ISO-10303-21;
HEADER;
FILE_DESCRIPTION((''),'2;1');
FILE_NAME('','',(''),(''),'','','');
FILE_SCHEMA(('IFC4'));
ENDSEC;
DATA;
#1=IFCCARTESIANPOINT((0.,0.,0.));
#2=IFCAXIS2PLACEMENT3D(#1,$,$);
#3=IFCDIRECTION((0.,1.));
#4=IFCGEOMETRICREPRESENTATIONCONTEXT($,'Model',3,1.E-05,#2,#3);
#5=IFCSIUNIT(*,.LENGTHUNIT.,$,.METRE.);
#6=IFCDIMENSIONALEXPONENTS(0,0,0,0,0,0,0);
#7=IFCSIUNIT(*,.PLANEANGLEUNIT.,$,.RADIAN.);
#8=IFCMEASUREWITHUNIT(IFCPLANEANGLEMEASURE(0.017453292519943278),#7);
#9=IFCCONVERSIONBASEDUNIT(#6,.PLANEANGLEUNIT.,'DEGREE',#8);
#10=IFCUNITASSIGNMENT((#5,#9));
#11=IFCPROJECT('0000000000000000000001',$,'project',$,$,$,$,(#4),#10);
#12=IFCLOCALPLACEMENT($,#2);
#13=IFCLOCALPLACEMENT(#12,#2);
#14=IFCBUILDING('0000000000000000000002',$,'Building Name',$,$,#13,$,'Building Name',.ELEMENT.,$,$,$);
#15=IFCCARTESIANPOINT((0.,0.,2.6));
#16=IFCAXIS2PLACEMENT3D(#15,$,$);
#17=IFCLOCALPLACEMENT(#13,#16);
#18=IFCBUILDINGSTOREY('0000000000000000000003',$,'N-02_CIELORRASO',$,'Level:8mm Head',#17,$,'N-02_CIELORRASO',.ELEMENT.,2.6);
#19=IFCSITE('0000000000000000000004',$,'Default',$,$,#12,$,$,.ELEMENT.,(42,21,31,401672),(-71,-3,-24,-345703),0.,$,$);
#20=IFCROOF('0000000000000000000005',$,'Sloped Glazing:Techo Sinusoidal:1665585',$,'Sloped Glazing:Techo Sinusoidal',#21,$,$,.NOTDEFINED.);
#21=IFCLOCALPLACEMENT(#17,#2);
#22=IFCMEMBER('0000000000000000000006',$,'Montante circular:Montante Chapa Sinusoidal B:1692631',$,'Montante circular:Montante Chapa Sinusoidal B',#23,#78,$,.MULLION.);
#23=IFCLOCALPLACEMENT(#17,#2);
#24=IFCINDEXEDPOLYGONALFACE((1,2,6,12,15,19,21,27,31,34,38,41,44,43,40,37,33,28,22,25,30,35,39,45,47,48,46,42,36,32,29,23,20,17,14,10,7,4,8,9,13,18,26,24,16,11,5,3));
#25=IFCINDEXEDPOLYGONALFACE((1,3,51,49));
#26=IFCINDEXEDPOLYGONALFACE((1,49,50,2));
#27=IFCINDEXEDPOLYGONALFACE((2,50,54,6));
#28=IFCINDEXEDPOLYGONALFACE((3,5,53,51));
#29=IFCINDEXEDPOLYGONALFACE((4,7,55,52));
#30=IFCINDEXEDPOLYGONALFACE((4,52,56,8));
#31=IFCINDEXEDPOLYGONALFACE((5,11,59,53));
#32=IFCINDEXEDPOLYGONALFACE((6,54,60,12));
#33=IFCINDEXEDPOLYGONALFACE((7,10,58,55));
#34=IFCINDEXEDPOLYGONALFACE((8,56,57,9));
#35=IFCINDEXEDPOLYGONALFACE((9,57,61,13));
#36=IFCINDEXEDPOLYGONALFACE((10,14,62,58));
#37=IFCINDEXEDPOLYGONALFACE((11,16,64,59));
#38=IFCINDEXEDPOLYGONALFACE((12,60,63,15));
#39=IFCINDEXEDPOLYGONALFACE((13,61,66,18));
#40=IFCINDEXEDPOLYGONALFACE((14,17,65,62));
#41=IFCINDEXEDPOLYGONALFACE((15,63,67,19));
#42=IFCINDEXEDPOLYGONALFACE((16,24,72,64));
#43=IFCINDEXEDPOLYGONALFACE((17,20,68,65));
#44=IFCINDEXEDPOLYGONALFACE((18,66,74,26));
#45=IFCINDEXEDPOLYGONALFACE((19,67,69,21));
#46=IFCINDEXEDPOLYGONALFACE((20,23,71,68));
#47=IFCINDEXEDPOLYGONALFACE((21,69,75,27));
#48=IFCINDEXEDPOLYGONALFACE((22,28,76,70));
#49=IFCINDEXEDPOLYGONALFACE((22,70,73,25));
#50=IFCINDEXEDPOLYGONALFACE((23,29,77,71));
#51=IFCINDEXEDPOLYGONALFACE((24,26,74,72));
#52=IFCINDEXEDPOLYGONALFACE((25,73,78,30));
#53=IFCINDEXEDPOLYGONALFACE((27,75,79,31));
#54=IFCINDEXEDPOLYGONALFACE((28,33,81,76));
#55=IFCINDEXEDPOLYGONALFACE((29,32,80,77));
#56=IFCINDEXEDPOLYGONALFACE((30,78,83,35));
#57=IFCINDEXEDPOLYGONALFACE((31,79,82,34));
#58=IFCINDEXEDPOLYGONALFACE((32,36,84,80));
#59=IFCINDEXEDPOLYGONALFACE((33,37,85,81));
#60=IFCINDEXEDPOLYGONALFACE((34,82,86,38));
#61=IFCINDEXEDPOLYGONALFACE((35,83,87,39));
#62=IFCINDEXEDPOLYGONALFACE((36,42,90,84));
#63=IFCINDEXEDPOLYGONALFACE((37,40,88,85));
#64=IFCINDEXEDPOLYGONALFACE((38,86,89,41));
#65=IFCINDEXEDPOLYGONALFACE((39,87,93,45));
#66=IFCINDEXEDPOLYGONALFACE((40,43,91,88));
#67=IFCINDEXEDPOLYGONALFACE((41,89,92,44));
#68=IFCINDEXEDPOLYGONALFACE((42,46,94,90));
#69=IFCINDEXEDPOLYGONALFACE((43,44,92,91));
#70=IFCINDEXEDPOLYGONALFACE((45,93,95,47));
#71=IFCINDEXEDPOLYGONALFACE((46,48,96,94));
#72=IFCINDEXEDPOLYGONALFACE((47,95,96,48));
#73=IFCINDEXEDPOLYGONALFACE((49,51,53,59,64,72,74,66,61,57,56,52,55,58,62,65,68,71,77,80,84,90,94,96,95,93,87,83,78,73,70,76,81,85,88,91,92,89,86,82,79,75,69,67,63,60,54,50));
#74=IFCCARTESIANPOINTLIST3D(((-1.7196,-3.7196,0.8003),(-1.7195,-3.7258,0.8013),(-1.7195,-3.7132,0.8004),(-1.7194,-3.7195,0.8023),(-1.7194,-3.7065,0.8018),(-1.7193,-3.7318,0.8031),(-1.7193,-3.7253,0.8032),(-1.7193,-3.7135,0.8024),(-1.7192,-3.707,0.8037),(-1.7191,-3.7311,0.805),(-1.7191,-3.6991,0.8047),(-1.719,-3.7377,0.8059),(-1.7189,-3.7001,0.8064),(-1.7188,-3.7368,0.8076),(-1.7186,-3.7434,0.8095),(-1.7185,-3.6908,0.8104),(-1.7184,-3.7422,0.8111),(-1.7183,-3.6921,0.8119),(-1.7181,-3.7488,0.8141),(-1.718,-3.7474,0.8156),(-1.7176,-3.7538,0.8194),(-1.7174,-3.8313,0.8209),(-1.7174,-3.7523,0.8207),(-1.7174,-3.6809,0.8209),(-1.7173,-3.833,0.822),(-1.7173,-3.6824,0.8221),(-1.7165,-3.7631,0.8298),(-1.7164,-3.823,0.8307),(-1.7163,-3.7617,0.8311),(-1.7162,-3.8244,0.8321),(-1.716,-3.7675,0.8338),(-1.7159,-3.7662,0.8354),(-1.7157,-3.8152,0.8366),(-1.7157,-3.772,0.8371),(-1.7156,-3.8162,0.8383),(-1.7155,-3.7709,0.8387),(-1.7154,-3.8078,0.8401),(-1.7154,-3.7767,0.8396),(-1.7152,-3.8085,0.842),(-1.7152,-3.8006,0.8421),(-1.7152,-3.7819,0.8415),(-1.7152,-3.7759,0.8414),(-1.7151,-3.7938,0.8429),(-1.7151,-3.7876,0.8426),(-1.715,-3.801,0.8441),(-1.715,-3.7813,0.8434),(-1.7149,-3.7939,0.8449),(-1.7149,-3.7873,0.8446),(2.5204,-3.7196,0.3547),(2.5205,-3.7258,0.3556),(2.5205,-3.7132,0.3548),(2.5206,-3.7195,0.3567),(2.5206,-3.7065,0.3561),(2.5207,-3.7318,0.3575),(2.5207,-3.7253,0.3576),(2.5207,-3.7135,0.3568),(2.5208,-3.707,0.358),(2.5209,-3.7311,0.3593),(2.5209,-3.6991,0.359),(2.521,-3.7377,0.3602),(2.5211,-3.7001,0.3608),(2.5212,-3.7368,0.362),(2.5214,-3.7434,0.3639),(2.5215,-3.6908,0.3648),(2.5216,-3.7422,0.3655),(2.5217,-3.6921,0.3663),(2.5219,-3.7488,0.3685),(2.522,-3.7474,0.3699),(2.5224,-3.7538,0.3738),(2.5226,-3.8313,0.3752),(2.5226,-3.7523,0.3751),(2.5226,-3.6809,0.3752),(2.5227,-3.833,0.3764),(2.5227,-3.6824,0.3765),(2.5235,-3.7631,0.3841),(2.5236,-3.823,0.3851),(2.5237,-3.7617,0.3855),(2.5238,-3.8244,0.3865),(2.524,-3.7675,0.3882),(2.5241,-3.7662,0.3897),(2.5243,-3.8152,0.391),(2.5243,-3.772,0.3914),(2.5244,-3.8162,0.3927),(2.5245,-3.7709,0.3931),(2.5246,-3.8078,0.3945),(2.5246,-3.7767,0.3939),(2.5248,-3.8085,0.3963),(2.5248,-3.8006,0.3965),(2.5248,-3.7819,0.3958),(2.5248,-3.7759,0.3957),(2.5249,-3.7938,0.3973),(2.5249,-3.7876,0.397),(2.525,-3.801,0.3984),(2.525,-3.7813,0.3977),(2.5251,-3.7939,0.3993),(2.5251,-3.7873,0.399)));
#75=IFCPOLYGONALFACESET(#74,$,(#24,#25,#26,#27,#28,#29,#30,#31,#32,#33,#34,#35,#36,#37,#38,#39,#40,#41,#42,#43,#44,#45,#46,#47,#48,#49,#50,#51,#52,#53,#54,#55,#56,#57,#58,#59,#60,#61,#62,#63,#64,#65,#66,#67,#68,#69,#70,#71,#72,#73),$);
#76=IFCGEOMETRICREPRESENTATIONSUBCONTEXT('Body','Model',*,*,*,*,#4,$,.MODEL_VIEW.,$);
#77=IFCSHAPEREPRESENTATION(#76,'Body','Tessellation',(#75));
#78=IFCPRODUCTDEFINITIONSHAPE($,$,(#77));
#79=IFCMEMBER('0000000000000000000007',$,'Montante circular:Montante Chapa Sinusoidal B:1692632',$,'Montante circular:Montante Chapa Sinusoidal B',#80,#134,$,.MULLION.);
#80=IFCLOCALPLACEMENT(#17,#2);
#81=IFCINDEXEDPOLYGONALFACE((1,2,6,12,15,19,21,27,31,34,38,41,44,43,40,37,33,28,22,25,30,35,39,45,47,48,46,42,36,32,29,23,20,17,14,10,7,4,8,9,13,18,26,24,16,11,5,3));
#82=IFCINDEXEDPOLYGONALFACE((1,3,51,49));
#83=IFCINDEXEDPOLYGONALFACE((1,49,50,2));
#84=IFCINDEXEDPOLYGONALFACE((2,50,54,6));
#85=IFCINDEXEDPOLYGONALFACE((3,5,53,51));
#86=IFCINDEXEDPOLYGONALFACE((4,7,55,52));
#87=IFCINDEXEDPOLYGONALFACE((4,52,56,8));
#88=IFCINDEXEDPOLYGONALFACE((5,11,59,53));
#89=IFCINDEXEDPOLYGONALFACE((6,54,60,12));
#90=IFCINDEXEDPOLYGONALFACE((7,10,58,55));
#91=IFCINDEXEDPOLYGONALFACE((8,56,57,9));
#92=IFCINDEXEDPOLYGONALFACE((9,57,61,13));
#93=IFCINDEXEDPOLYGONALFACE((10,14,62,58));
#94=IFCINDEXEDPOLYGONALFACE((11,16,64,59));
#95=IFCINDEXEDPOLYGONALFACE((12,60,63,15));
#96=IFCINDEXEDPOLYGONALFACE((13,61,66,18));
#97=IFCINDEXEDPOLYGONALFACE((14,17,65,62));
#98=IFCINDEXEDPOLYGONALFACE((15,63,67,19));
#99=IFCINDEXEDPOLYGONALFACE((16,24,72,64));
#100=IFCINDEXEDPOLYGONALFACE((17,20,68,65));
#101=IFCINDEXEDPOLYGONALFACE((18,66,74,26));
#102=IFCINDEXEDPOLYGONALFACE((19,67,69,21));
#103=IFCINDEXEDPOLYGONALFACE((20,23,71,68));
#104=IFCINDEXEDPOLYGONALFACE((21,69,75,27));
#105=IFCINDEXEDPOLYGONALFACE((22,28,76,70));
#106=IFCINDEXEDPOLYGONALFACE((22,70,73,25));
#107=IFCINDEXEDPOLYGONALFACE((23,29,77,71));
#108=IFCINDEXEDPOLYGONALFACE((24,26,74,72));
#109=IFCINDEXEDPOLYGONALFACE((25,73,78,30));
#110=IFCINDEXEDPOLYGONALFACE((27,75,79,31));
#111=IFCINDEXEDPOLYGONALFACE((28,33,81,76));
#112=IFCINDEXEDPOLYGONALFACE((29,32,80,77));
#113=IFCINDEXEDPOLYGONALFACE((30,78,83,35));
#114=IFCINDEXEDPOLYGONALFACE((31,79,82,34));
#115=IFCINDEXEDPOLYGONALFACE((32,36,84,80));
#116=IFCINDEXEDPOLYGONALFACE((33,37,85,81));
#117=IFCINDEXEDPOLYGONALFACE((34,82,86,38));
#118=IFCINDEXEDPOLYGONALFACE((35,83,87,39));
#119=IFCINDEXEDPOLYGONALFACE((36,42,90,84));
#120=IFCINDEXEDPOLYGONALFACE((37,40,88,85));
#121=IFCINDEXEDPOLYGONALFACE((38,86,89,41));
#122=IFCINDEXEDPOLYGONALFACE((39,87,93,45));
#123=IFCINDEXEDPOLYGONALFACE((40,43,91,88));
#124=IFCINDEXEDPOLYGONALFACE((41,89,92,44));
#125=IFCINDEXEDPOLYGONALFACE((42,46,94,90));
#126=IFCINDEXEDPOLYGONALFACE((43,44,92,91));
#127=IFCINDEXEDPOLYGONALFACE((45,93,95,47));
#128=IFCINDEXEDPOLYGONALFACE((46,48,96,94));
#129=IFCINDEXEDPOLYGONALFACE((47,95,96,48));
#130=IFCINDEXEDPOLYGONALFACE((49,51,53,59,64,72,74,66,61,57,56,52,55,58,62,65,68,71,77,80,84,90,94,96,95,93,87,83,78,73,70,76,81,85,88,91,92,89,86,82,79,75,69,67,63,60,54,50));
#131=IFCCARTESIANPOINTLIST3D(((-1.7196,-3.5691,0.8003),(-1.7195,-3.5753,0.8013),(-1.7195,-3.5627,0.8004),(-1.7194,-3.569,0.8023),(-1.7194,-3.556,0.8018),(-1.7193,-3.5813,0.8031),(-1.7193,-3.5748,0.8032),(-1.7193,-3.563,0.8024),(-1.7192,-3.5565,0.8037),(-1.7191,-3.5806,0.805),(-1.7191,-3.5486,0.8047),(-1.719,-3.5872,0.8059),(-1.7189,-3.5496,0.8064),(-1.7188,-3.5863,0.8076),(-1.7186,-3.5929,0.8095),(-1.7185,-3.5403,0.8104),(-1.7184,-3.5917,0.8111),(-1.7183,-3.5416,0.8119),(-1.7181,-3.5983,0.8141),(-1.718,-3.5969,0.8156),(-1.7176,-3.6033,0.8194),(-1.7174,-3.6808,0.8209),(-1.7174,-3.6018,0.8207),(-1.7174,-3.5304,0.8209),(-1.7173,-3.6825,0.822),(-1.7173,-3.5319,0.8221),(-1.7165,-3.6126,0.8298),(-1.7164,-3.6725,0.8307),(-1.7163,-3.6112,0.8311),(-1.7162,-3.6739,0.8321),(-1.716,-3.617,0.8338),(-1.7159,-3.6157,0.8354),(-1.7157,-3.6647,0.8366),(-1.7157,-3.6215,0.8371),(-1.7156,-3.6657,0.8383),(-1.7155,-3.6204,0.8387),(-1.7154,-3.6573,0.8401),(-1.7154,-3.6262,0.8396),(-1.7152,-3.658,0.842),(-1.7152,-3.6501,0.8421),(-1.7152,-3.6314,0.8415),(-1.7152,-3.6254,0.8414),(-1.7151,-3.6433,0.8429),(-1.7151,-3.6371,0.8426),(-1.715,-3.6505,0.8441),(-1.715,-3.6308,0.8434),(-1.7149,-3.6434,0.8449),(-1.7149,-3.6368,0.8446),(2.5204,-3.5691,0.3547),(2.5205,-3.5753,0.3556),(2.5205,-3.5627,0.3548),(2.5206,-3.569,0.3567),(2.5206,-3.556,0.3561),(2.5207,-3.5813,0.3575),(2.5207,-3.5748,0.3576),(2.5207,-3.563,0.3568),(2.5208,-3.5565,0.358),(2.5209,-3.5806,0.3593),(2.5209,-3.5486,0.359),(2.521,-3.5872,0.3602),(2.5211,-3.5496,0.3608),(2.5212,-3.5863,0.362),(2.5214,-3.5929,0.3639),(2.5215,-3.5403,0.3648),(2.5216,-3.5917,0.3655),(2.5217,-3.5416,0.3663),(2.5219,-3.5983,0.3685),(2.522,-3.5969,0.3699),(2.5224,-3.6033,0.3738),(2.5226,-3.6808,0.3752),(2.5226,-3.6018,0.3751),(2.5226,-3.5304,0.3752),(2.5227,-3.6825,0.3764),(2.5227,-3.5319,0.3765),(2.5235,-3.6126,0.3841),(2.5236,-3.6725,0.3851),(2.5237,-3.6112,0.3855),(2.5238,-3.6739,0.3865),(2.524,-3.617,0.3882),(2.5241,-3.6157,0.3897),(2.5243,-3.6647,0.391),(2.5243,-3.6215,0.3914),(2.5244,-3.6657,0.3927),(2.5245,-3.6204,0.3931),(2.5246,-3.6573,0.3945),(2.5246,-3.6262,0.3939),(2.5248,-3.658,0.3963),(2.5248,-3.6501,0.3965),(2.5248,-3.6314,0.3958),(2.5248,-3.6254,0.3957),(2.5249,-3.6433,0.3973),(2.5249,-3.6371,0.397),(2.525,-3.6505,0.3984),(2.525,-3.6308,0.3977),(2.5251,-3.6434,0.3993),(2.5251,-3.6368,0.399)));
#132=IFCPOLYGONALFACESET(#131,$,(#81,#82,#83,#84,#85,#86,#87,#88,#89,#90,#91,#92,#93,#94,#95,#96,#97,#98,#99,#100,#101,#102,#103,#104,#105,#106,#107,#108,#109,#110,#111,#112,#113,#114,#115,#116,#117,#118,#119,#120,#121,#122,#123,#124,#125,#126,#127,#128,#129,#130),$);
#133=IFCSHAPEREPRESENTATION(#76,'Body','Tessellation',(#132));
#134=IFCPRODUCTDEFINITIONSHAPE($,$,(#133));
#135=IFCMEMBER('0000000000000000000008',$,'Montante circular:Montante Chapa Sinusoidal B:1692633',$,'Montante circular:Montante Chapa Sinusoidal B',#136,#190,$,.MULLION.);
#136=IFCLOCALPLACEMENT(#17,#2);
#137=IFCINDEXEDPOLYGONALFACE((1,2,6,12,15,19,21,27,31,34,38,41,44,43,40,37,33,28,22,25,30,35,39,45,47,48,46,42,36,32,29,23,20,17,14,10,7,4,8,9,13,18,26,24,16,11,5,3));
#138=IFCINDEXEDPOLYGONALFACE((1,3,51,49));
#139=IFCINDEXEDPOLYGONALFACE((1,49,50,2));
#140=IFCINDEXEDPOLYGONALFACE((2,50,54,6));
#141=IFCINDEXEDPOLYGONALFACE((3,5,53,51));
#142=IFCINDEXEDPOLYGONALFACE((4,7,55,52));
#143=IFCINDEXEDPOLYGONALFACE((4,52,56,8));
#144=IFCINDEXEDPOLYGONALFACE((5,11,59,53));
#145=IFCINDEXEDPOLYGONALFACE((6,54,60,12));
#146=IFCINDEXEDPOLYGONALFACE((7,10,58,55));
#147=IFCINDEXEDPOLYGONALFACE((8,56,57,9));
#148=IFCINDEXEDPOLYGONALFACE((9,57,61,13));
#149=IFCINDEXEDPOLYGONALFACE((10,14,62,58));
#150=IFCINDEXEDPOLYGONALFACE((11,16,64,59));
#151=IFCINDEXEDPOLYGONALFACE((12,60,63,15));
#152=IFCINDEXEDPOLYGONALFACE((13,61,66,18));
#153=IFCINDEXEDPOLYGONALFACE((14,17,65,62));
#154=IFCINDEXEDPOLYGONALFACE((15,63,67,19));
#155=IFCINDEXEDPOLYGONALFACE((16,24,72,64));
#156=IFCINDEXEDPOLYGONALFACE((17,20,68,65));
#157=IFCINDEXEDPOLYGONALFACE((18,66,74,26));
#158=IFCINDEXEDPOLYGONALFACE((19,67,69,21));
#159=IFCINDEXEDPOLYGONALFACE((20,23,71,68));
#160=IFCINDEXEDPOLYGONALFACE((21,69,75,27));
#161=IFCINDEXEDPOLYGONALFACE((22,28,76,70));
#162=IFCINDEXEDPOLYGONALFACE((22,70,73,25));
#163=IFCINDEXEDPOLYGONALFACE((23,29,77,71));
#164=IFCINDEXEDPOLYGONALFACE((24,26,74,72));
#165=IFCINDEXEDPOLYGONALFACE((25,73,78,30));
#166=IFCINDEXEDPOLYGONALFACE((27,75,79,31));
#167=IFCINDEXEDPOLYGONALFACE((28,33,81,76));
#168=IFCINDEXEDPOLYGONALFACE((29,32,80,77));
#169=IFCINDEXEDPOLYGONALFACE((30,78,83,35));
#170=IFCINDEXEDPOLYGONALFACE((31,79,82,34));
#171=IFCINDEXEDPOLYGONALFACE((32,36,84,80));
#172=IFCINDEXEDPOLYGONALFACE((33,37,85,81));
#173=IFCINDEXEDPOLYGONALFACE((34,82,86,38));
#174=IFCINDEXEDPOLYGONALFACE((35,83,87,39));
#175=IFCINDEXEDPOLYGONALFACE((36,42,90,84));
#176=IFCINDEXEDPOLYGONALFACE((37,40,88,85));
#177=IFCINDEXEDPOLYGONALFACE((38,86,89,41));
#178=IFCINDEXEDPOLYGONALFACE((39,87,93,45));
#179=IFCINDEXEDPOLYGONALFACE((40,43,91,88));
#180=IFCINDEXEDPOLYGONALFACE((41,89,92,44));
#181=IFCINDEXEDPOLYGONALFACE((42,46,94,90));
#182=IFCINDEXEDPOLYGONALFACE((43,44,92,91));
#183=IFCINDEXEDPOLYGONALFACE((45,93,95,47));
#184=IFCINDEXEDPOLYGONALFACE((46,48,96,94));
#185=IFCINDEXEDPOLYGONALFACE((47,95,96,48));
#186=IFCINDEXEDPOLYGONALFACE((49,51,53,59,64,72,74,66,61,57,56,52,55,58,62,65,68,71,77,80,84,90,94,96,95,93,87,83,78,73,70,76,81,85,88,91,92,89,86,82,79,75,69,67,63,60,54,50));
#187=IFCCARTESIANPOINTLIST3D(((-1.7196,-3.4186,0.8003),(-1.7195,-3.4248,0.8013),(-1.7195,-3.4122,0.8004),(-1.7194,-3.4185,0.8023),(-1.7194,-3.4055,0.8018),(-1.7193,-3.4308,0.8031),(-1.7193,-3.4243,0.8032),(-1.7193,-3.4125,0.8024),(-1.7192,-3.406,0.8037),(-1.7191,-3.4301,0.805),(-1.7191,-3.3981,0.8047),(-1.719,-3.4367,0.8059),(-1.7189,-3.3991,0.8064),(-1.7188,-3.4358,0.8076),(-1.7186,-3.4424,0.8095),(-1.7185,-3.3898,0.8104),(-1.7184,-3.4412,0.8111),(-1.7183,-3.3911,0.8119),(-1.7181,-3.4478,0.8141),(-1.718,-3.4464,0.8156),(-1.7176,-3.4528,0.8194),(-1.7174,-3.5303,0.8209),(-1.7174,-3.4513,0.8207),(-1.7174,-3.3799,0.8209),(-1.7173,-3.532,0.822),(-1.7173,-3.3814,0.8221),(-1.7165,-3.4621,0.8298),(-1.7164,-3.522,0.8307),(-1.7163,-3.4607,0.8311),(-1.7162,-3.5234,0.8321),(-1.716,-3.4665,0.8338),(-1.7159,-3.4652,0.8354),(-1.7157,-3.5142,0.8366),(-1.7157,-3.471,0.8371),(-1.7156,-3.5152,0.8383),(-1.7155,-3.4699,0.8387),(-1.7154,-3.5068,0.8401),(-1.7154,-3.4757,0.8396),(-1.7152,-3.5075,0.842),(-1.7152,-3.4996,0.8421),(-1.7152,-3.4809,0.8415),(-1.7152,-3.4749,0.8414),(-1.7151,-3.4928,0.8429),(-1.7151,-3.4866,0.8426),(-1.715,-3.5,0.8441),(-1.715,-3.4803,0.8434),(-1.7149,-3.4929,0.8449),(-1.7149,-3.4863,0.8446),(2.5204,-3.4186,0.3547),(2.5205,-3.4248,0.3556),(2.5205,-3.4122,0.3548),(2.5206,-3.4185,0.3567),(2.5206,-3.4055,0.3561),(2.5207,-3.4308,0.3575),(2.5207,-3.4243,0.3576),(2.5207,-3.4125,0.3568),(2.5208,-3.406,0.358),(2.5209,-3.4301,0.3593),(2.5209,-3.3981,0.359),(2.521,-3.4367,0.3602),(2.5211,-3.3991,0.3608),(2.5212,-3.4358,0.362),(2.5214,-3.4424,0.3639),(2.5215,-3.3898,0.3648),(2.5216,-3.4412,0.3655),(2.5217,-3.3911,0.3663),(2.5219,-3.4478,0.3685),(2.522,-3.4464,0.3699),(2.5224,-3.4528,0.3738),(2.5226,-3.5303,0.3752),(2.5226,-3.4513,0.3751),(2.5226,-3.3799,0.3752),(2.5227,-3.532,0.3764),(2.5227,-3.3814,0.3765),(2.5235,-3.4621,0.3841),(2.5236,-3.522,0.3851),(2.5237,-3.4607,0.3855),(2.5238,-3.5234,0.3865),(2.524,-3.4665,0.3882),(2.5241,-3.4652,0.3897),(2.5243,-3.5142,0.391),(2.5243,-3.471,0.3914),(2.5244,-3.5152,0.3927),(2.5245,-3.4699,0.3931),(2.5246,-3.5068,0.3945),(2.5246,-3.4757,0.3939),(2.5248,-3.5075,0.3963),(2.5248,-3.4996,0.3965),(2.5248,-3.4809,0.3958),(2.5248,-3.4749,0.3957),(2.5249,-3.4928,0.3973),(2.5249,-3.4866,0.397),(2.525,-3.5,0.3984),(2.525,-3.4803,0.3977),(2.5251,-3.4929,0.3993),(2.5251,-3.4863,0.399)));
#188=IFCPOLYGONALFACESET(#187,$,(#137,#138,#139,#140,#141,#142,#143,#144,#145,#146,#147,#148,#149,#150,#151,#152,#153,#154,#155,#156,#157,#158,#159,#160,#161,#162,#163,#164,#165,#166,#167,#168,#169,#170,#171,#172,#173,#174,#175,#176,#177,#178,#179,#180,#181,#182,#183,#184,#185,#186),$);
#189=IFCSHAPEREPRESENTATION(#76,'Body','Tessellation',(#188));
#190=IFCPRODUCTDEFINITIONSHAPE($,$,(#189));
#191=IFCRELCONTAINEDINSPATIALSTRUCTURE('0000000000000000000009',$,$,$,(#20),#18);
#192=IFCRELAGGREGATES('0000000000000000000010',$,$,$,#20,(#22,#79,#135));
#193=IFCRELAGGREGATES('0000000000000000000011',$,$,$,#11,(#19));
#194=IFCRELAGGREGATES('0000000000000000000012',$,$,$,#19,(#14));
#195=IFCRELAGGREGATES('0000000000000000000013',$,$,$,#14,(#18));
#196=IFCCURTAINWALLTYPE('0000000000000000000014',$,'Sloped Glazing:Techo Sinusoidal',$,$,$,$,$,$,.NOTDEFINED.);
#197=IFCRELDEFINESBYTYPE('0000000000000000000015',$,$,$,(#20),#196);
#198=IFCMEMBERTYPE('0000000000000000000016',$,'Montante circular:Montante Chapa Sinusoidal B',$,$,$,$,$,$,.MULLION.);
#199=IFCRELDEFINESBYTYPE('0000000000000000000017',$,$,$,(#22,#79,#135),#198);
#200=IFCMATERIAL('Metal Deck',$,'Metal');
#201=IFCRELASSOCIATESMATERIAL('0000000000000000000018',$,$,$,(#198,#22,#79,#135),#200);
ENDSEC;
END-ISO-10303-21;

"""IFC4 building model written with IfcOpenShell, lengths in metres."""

from ifc_helpers import new_model, entity, si_unit, converted_unit, direction, frame, origin, place, context, subcontext, project, spatial, indexed_curve, outline, extrude, source, transform, mapped, material, type_object, type_shapes, element, aggregate, save


model = new_model("IFC4")

# Units and contexts
model_context = context("Model", 3, precision=1e-05, world=origin(), true_north=direction((0.0, 1.0)))
body_context = subcontext(model_context, "Body", "Model", "MODEL_VIEW")
ifc_project = project(units=[si_unit("LENGTHUNIT", "METRE"), converted_unit("PLANEANGLEUNIT", "DEGREE", entity("IfcPlaneAngleMeasure", 0.017453292519943278), si_unit("PLANEANGLEUNIT", "RADIAN"), dimensions=[0, 0, 0, 0, 0, 0, 0])], contexts=[model_context])

# Site, building, storey
site_placement = place(None, origin())
site = spatial("IfcSite", under=ifc_project, at=site_placement, Name="Default", CompositionType="ELEMENT", RefLatitude=(42, 21, 31, 401672), RefLongitude=(-71, -3, -24, -345703), RefElevation=0.0)
building_placement = place(site_placement, origin())
building = spatial("IfcBuilding", under=site, at=building_placement, Name="Building Name", LongName="Building Name", CompositionType="ELEMENT")
storey_placement = place(building_placement, frame((0.0, 0.0, 2.6)))
storey = spatial("IfcBuildingStorey", under=building, at=storey_placement, Name="N-02_CIELORRASO", ObjectType="Level:8mm Head", LongName="N-02_CIELORRASO", CompositionType="ELEMENT", Elevation=2.6)

# Roof, members
curtain_wall_type = type_object("IfcCurtainWallType", Name="Sloped Glazing:Techo Sinusoidal", PredefinedType="NOTDEFINED")
roof_1_placement = place(storey_placement, frame((0.0, 0.0, -2.6)))
roof_1 = element("IfcRoof", 1, at=roof_1_placement, inside=storey, type_object=curtain_wall_type, Name="Sloped Glazing:Techo Sinusoidal:1665585", ObjectType="Sloped Glazing:Techo Sinusoidal", PredefinedType="NOTDEFINED")
ifc_material = material(Name="Metal Deck", Category="Metal")
member_type_1 = type_object("IfcMemberType", Name="Montante circular:Montante Chapa Sinusoidal B", PredefinedType="MULLION", material=ifc_material)
shared_shape_1 = source(origin(), body_context, "Body", "SweptSolid", [
    extrude(outline(indexed_curve([(0.0595, -0.0443), (0.0615, -0.0443), (0.0603, -0.031), (0.0572, -0.0213), (0.053, -0.0138), (0.0481, -0.0078), (0.0427, -0.003), (0.0372, 0.0005), (0.0315, 0.0029), (0.0259, 0.0044), (0.0203, 0.0051), (0.0146, 0.005), (0.0084, 0.0041), (-0.0053, 0.0009), (-0.0123, -0.0005), (-0.0191, -0.0012), (-0.0256, -0.001), (-0.0317, 0.0001), (-0.0375, 0.0019), (-0.0428, 0.0046), (-0.0477, 0.0081), (-0.0522, 0.0128), (-0.0563, 0.0191), (-0.0597, 0.0282), (-0.0617, 0.0421), (-0.0637, 0.042), (-0.0616, 0.0277), (-0.0581, 0.0182), (-0.0537, 0.0116), (-0.049, 0.0066), (-0.0438, 0.0028), (-0.0382, 0.0001), (-0.0322, -0.0019), (-0.0258, -0.003), (-0.019, -0.0032), (-0.012, -0.0025), (-0.0048, -0.0011), (0.0088, 0.0021), (0.0147, 0.003), (0.0202, 0.0031), (0.0255, 0.0024), (0.0309, 0.001), (0.0362, -0.0013), (0.0415, -0.0046), (0.0466, -0.0092), (0.0513, -0.0149), (0.0554, -0.0221), (0.0584, -0.0314), (0.0595, -0.0443)], self_intersect=False)), frame((-0.007, 0.0228, -4.2634), z_axis=(0.0, 0.0, 1.0), x_axis=(-0.819152, -0.573576, 0.0)), (0.0, 0.0, 1.0), 4.2634),
])
type_shapes(member_type_1, [shared_shape_1])
member_1_placement = place(roof_1_placement, frame((-1.7148, -3.7501, 3.4456), z_axis=(-0.994522, 0.0, 0.104528), x_axis=(0.0, 1.0, 0.0)))
member_1 = element("IfcMember", 2, at=member_1_placement, type_object=member_type_1, material=ifc_material, Name="Montante circular:Montante Chapa Sinusoidal B:1692631", ObjectType="Montante circular:Montante Chapa Sinusoidal B", PredefinedType="MULLION", context=body_context, shape_type="MappedRepresentation", body=[
    mapped(shared_shape_1, transform((0.0, 0.0, 0.0), scale=1.0)),
])
member_2_placement = place(roof_1_placement, frame((-1.7148, -3.5996, 3.4456), z_axis=(-0.994522, 0.0, 0.104528), x_axis=(0.0, 1.0, 0.0)))
member_2 = element("IfcMember", 3, at=member_2_placement, type_object=member_type_1, material=ifc_material, Name="Montante circular:Montante Chapa Sinusoidal B:1692632", ObjectType="Montante circular:Montante Chapa Sinusoidal B", PredefinedType="MULLION", context=body_context, shape_type="MappedRepresentation", body=[
    mapped(shared_shape_1, transform((0.0, 0.0, 0.0), scale=1.0)),
])
member_3_placement = place(roof_1_placement, frame((-1.7148, -3.4491, 3.4456), z_axis=(-0.994522, 0.0, 0.104528), x_axis=(0.0, 1.0, 0.0)))
member_3 = element("IfcMember", 4, at=member_3_placement, type_object=member_type_1, material=ifc_material, Name="Montante circular:Montante Chapa Sinusoidal B:1692633", ObjectType="Montante circular:Montante Chapa Sinusoidal B", PredefinedType="MULLION", context=body_context, shape_type="MappedRepresentation", body=[
    mapped(shared_shape_1, transform((0.0, 0.0, 0.0), scale=1.0)),
])
aggregate(roof_1, [member_1, member_2, member_3])

save(model, "model.ifc")
